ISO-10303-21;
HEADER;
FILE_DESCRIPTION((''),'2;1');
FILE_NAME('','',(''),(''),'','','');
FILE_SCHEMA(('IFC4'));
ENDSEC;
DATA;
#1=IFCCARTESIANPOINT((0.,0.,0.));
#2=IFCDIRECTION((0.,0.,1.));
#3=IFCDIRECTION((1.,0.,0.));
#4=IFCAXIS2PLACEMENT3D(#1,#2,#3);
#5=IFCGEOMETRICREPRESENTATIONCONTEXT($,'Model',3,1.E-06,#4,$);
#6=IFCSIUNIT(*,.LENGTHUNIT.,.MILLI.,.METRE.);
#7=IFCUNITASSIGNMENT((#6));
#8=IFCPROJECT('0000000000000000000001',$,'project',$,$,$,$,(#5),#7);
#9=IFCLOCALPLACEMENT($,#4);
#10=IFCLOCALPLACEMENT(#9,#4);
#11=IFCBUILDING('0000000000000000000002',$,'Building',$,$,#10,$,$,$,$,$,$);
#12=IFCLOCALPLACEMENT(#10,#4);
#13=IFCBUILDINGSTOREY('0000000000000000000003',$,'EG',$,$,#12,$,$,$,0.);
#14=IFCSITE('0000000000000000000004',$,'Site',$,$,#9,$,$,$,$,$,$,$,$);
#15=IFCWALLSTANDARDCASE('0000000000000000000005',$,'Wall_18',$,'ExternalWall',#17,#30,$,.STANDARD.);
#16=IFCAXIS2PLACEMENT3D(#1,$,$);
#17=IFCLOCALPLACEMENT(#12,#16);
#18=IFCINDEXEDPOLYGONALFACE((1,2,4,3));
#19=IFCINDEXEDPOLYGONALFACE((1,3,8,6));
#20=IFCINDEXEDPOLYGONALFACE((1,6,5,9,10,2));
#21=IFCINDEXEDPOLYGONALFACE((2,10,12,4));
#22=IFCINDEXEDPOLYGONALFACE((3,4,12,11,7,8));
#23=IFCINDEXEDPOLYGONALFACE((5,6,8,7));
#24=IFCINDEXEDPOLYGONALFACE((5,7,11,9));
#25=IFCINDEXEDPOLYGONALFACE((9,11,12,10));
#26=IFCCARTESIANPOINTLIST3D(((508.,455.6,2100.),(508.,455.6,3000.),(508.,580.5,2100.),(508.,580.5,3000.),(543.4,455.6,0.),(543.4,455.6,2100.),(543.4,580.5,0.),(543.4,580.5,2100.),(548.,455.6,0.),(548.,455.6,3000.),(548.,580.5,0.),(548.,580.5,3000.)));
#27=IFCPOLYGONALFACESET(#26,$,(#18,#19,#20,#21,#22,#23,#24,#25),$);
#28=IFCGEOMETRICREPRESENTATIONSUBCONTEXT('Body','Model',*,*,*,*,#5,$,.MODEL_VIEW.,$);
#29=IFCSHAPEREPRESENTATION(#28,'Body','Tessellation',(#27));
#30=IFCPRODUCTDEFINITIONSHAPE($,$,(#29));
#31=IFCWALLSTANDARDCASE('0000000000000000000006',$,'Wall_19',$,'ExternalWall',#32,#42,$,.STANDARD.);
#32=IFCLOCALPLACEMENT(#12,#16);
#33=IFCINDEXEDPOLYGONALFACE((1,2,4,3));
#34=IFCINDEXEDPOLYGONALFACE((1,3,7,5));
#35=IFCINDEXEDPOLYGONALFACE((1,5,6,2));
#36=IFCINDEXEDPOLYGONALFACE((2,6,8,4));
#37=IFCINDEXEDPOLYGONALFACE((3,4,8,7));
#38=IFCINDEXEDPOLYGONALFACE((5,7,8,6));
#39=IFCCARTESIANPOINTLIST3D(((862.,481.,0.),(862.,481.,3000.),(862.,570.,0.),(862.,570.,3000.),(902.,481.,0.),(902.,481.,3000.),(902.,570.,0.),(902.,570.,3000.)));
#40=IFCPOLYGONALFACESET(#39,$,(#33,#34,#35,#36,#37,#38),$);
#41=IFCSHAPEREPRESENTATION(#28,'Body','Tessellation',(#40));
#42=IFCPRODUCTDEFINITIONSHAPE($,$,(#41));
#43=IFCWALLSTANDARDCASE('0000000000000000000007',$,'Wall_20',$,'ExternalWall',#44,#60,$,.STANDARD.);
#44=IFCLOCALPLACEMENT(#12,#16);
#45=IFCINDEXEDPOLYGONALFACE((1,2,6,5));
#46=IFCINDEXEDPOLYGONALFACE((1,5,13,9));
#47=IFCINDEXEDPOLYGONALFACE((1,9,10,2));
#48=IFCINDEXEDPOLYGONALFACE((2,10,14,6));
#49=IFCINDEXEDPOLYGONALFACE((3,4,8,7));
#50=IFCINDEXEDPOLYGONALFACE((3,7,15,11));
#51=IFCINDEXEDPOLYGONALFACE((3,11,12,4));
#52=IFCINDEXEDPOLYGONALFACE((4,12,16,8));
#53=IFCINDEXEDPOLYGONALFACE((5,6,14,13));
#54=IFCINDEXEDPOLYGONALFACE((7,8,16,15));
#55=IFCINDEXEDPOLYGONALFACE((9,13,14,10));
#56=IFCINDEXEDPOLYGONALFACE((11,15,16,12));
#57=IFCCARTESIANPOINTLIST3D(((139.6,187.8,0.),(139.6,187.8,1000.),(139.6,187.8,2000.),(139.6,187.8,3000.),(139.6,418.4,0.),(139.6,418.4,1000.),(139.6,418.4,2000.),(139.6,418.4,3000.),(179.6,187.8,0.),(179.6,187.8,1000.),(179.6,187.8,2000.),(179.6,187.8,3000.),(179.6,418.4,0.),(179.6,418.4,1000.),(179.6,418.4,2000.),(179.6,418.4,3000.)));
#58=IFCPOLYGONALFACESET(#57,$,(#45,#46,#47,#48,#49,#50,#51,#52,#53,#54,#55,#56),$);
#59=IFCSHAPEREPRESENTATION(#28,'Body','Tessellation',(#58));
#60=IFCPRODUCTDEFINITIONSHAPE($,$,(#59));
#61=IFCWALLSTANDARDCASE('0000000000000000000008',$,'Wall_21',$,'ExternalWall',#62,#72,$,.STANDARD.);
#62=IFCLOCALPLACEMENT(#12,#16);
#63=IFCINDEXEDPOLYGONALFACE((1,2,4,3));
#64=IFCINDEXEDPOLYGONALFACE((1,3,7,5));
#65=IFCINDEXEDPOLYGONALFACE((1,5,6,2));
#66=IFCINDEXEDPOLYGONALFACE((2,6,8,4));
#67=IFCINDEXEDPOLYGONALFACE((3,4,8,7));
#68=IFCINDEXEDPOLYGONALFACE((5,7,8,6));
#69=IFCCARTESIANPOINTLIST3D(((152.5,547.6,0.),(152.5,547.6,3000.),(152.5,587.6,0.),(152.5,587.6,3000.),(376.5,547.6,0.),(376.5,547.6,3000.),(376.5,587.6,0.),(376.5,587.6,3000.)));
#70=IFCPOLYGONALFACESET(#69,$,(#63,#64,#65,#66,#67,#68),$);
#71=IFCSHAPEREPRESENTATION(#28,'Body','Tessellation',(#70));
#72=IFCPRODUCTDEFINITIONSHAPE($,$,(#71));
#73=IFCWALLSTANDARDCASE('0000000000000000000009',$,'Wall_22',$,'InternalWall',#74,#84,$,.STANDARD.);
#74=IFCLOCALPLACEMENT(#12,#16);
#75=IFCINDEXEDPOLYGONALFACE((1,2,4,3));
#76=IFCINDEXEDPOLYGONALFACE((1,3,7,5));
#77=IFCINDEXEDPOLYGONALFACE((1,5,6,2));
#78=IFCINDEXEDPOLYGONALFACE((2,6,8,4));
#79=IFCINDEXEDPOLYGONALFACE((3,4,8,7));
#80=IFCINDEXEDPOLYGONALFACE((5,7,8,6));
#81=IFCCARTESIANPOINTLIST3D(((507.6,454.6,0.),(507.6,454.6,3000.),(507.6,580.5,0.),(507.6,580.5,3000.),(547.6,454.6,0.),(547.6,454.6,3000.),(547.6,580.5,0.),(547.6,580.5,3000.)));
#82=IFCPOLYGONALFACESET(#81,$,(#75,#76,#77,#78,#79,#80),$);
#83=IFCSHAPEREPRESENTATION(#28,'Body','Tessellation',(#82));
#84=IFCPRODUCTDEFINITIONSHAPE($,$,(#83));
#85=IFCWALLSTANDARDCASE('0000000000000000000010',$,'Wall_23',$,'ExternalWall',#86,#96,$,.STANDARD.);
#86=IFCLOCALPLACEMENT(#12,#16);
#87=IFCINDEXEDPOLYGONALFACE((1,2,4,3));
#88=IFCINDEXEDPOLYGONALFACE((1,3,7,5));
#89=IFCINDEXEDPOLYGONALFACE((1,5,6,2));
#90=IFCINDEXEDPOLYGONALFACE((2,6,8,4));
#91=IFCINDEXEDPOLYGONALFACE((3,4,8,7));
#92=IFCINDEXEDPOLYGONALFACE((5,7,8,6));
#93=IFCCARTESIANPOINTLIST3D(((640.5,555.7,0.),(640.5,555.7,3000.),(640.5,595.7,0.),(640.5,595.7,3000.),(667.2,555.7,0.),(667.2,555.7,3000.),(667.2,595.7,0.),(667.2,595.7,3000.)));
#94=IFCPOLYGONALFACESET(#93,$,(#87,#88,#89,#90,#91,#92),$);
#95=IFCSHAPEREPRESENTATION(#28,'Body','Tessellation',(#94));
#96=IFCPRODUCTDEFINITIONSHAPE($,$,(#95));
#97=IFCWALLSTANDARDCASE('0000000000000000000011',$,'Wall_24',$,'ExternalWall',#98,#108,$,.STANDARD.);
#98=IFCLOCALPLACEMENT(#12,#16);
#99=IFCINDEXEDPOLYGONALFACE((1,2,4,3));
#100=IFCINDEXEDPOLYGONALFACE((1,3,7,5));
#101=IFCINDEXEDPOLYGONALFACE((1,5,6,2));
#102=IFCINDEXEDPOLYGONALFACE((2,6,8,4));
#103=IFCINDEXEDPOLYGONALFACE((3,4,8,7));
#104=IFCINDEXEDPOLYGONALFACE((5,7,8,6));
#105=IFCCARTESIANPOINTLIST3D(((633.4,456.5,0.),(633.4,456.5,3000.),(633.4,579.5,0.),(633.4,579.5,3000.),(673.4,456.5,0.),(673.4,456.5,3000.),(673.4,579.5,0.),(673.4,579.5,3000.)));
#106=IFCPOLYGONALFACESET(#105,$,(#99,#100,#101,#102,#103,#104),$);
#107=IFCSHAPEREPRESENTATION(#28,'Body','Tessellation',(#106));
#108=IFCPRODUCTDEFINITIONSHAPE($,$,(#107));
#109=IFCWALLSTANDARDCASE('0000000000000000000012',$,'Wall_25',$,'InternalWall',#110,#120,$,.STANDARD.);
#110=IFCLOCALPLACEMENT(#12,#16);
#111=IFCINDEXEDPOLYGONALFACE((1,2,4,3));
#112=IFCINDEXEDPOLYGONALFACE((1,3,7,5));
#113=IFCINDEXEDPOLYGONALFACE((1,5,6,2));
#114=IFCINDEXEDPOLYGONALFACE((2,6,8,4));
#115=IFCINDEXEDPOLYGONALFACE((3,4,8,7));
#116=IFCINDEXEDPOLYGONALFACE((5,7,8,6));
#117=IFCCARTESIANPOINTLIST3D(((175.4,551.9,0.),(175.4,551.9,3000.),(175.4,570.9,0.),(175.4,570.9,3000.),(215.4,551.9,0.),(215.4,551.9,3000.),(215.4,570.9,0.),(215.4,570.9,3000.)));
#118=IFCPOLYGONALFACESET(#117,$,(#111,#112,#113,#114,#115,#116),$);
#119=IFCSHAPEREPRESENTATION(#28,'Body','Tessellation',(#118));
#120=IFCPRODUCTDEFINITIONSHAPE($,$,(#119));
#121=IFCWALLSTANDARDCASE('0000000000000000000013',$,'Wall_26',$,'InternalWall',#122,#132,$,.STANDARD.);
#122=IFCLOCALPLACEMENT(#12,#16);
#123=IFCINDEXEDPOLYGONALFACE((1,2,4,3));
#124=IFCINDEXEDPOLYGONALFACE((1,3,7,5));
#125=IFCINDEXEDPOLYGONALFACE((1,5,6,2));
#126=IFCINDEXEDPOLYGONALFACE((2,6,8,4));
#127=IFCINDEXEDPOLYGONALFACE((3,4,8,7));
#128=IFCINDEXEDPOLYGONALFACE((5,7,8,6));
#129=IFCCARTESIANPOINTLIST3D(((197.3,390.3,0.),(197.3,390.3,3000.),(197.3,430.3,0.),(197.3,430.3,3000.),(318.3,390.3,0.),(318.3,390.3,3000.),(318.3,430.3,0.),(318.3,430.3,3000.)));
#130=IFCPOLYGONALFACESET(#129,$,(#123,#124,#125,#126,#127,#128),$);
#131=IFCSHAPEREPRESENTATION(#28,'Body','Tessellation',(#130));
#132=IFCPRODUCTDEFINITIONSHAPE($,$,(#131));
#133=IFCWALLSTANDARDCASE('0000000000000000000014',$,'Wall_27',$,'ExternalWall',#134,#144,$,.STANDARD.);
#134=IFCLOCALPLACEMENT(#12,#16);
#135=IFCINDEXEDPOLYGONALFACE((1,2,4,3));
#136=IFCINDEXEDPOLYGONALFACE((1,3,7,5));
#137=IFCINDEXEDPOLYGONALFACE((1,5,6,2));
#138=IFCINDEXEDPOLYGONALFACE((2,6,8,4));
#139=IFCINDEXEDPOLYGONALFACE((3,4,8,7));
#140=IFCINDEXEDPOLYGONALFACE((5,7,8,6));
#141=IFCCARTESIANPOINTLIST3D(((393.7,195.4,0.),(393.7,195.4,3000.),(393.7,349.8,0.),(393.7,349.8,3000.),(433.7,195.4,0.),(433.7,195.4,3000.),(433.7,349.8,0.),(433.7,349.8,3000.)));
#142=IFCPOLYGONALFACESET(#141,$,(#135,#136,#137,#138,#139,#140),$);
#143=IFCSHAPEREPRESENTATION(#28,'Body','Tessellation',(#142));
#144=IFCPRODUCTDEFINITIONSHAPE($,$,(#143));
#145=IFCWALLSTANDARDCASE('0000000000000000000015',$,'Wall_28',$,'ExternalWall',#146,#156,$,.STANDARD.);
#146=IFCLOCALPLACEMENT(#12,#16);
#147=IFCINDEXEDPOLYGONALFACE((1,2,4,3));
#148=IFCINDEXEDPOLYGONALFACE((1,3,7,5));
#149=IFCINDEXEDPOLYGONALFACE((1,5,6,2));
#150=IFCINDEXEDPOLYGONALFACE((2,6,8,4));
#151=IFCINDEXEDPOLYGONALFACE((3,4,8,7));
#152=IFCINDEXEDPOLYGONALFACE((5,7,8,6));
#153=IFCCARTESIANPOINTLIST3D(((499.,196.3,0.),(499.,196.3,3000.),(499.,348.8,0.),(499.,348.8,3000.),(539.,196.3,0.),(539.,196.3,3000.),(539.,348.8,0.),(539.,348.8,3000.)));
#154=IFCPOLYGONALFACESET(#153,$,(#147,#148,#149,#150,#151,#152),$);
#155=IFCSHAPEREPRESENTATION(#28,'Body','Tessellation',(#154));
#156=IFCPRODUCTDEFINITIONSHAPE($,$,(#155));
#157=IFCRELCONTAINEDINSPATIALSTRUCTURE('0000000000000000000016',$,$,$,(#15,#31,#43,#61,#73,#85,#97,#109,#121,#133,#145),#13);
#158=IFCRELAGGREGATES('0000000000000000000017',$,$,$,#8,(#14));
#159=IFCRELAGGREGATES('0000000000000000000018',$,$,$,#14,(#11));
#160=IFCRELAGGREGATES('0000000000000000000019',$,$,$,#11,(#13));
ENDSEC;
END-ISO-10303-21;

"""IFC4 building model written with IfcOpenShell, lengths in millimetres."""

from ifc_helpers import new_model, si_unit, frame, origin_with_axes, place, context, subcontext, project, spatial, rectangle, extrude, element, save


model = new_model("IFC4")

# Units and contexts
model_context = context("Model", 3, precision=1e-06, world=origin_with_axes())
body_context = subcontext(model_context, "Body", "Model", "MODEL_VIEW")
ifc_project = project(units=[si_unit("LENGTHUNIT", "METRE", prefix="MILLI")], contexts=[model_context])

# Site, building, storey
site_placement = place(None, origin_with_axes())
site = spatial("IfcSite", under=ifc_project, at=site_placement, Name="Site")
building_placement = place(site_placement, origin_with_axes())
building = spatial("IfcBuilding", under=site, at=building_placement, Name="Building")
storey_placement = place(building_placement, origin_with_axes())
storey = spatial("IfcBuildingStorey", under=building, at=storey_placement, Name="EG", Elevation=0.0)

# Wall, opening
wall_1_placement = place(storey_placement, origin_with_axes())
wall_1 = element("IfcWallStandardCase", 1, at=wall_1_placement, inside=storey, Name="Wall_18", ObjectType="ExternalWall", PredefinedType="STANDARD", context=body_context, shape_type="SweptSolid", body=[
    extrude(rectangle(XDim=124.9, YDim=40.0), frame((528.0, 518.0, 0.0), z_axis=(0.0, 0.0, 1.0), x_axis=(0.0, 1.0, 0.0)), (0.0, 0.0, 1.0), 3000.0),
])
opening_1_placement = place(wall_1_placement, origin_with_axes())
element("IfcOpeningElement", 2, at=opening_1_placement, inside=storey, cuts=wall_1, context=body_context, shape_type="SweptSolid", body=[
    extrude(rectangle(XDim=900.0, YDim=40.0), frame((523.4, 438.6, 0.0), z_axis=(0.0, 0.0, 1.0), x_axis=(0.0, 1.0, 0.0)), (0.0, 0.0, 1.0), 2100.0),
])

# Wall
wall_2_placement = place(storey_placement, origin_with_axes())
element("IfcWallStandardCase", 3, at=wall_2_placement, inside=storey, Name="Wall_19", ObjectType="ExternalWall", PredefinedType="STANDARD", context=body_context, shape_type="SweptSolid", body=[
    extrude(rectangle(XDim=89.0, YDim=40.0), frame((882.0, 525.5, 0.0), z_axis=(0.0, 0.0, 1.0), x_axis=(0.0, 1.0, 0.0)), (0.0, 0.0, 1.0), 3000.0),
])

# Wall, opening
wall_3_placement = place(storey_placement, origin_with_axes())
wall_3 = element("IfcWallStandardCase", 4, at=wall_3_placement, inside=storey, Name="Wall_20", ObjectType="ExternalWall", PredefinedType="STANDARD", context=body_context, shape_type="SweptSolid", body=[
    extrude(rectangle(XDim=230.7, YDim=40.0), frame((159.6, 303.1, 0.0), z_axis=(0.0, 0.0, 1.0), x_axis=(0.0, 1.0, 0.0)), (0.0, 0.0, 1.0), 3000.0),
])
opening_2_placement = place(wall_3_placement, origin_with_axes())
element("IfcOpeningElement", 5, at=opening_2_placement, inside=storey, cuts=wall_3, context=body_context, shape_type="SweptSolid", body=[
    extrude(rectangle(XDim=600.0, YDim=40.0), frame((159.6, 192.5, 1000.0), z_axis=(0.0, 0.0, 1.0), x_axis=(0.0, 1.0, 0.0)), (0.0, 0.0, 1.0), 1000.0),
])

# Walls
wall_4_placement = place(storey_placement, origin_with_axes())
element("IfcWallStandardCase", 6, at=wall_4_placement, inside=storey, Name="Wall_21", ObjectType="ExternalWall", PredefinedType="STANDARD", context=body_context, shape_type="SweptSolid", body=[
    extrude(rectangle(XDim=224.0, YDim=40.0), frame((264.5, 567.6, 0.0), z_axis=(0.0, 0.0, 1.0), x_axis=(-1.0, 0.0, 0.0)), (0.0, 0.0, 1.0), 3000.0),
])
wall_5_placement = place(storey_placement, origin_with_axes())
element("IfcWallStandardCase", 7, at=wall_5_placement, inside=storey, Name="Wall_22", ObjectType="InternalWall", PredefinedType="STANDARD", context=body_context, shape_type="SweptSolid", body=[
    extrude(rectangle(XDim=125.8, YDim=40.0), frame((527.6, 517.5, 0.0), z_axis=(0.0, 0.0, 1.0), x_axis=(0.0, 1.0, 0.0)), (0.0, 0.0, 1.0), 3000.0),
])
wall_6_placement = place(storey_placement, origin_with_axes())
element("IfcWallStandardCase", 8, at=wall_6_placement, inside=storey, Name="Wall_23", ObjectType="ExternalWall", PredefinedType="STANDARD", context=body_context, shape_type="SweptSolid", body=[
    extrude(rectangle(XDim=26.7, YDim=40.0), frame((653.8, 575.7, 0.0), z_axis=(0.0, 0.0, 1.0), x_axis=(-1.0, 0.0, 0.0)), (0.0, 0.0, 1.0), 3000.0),
])
wall_7_placement = place(storey_placement, origin_with_axes())
element("IfcWallStandardCase", 9, at=wall_7_placement, inside=storey, Name="Wall_24", ObjectType="ExternalWall", PredefinedType="STANDARD", context=body_context, shape_type="SweptSolid", body=[
    extrude(rectangle(XDim=123.0, YDim=40.0), frame((653.4, 518.0, 0.0), z_axis=(0.0, 0.0, 1.0), x_axis=(0.0, 1.0, 0.0)), (0.0, 0.0, 1.0), 3000.0),
])
wall_8_placement = place(storey_placement, origin_with_axes())
element("IfcWallStandardCase", 10, at=wall_8_placement, inside=storey, Name="Wall_25", ObjectType="InternalWall", PredefinedType="STANDARD", context=body_context, shape_type="SweptSolid", body=[
    extrude(rectangle(XDim=19.1, YDim=40.0), frame((195.4, 561.4, 0.0), z_axis=(0.0, 0.0, 1.0), x_axis=(0.0, 1.0, 0.0)), (0.0, 0.0, 1.0), 3000.0),
])
wall_9_placement = place(storey_placement, origin_with_axes())
element("IfcWallStandardCase", 11, at=wall_9_placement, inside=storey, Name="Wall_26", ObjectType="InternalWall", PredefinedType="STANDARD", context=body_context, shape_type="SweptSolid", body=[
    extrude(rectangle(XDim=121.0, YDim=40.0), frame((257.8, 410.3, 0.0), z_axis=(0.0, 0.0, 1.0), x_axis=(-1.0, 0.0, 0.0)), (0.0, 0.0, 1.0), 3000.0),
])
wall_10_placement = place(storey_placement, origin_with_axes())
element("IfcWallStandardCase", 12, at=wall_10_placement, inside=storey, Name="Wall_27", ObjectType="ExternalWall", PredefinedType="STANDARD", context=body_context, shape_type="SweptSolid", body=[
    extrude(rectangle(XDim=154.4, YDim=40.0), frame((413.7, 272.6, 0.0), z_axis=(0.0, 0.0, 1.0), x_axis=(0.0, 1.0, 0.0)), (0.0, 0.0, 1.0), 3000.0),
])
wall_11_placement = place(storey_placement, origin_with_axes())
element("IfcWallStandardCase", 13, at=wall_11_placement, inside=storey, Name="Wall_28", ObjectType="ExternalWall", PredefinedType="STANDARD", context=body_context, shape_type="SweptSolid", body=[
    extrude(rectangle(XDim=152.5, YDim=40.0), frame((519.0, 272.6, 0.0), z_axis=(0.0, 0.0, 1.0), x_axis=(0.0, 1.0, 0.0)), (0.0, 0.0, 1.0), 3000.0),
])

save(model, "model.ifc")
